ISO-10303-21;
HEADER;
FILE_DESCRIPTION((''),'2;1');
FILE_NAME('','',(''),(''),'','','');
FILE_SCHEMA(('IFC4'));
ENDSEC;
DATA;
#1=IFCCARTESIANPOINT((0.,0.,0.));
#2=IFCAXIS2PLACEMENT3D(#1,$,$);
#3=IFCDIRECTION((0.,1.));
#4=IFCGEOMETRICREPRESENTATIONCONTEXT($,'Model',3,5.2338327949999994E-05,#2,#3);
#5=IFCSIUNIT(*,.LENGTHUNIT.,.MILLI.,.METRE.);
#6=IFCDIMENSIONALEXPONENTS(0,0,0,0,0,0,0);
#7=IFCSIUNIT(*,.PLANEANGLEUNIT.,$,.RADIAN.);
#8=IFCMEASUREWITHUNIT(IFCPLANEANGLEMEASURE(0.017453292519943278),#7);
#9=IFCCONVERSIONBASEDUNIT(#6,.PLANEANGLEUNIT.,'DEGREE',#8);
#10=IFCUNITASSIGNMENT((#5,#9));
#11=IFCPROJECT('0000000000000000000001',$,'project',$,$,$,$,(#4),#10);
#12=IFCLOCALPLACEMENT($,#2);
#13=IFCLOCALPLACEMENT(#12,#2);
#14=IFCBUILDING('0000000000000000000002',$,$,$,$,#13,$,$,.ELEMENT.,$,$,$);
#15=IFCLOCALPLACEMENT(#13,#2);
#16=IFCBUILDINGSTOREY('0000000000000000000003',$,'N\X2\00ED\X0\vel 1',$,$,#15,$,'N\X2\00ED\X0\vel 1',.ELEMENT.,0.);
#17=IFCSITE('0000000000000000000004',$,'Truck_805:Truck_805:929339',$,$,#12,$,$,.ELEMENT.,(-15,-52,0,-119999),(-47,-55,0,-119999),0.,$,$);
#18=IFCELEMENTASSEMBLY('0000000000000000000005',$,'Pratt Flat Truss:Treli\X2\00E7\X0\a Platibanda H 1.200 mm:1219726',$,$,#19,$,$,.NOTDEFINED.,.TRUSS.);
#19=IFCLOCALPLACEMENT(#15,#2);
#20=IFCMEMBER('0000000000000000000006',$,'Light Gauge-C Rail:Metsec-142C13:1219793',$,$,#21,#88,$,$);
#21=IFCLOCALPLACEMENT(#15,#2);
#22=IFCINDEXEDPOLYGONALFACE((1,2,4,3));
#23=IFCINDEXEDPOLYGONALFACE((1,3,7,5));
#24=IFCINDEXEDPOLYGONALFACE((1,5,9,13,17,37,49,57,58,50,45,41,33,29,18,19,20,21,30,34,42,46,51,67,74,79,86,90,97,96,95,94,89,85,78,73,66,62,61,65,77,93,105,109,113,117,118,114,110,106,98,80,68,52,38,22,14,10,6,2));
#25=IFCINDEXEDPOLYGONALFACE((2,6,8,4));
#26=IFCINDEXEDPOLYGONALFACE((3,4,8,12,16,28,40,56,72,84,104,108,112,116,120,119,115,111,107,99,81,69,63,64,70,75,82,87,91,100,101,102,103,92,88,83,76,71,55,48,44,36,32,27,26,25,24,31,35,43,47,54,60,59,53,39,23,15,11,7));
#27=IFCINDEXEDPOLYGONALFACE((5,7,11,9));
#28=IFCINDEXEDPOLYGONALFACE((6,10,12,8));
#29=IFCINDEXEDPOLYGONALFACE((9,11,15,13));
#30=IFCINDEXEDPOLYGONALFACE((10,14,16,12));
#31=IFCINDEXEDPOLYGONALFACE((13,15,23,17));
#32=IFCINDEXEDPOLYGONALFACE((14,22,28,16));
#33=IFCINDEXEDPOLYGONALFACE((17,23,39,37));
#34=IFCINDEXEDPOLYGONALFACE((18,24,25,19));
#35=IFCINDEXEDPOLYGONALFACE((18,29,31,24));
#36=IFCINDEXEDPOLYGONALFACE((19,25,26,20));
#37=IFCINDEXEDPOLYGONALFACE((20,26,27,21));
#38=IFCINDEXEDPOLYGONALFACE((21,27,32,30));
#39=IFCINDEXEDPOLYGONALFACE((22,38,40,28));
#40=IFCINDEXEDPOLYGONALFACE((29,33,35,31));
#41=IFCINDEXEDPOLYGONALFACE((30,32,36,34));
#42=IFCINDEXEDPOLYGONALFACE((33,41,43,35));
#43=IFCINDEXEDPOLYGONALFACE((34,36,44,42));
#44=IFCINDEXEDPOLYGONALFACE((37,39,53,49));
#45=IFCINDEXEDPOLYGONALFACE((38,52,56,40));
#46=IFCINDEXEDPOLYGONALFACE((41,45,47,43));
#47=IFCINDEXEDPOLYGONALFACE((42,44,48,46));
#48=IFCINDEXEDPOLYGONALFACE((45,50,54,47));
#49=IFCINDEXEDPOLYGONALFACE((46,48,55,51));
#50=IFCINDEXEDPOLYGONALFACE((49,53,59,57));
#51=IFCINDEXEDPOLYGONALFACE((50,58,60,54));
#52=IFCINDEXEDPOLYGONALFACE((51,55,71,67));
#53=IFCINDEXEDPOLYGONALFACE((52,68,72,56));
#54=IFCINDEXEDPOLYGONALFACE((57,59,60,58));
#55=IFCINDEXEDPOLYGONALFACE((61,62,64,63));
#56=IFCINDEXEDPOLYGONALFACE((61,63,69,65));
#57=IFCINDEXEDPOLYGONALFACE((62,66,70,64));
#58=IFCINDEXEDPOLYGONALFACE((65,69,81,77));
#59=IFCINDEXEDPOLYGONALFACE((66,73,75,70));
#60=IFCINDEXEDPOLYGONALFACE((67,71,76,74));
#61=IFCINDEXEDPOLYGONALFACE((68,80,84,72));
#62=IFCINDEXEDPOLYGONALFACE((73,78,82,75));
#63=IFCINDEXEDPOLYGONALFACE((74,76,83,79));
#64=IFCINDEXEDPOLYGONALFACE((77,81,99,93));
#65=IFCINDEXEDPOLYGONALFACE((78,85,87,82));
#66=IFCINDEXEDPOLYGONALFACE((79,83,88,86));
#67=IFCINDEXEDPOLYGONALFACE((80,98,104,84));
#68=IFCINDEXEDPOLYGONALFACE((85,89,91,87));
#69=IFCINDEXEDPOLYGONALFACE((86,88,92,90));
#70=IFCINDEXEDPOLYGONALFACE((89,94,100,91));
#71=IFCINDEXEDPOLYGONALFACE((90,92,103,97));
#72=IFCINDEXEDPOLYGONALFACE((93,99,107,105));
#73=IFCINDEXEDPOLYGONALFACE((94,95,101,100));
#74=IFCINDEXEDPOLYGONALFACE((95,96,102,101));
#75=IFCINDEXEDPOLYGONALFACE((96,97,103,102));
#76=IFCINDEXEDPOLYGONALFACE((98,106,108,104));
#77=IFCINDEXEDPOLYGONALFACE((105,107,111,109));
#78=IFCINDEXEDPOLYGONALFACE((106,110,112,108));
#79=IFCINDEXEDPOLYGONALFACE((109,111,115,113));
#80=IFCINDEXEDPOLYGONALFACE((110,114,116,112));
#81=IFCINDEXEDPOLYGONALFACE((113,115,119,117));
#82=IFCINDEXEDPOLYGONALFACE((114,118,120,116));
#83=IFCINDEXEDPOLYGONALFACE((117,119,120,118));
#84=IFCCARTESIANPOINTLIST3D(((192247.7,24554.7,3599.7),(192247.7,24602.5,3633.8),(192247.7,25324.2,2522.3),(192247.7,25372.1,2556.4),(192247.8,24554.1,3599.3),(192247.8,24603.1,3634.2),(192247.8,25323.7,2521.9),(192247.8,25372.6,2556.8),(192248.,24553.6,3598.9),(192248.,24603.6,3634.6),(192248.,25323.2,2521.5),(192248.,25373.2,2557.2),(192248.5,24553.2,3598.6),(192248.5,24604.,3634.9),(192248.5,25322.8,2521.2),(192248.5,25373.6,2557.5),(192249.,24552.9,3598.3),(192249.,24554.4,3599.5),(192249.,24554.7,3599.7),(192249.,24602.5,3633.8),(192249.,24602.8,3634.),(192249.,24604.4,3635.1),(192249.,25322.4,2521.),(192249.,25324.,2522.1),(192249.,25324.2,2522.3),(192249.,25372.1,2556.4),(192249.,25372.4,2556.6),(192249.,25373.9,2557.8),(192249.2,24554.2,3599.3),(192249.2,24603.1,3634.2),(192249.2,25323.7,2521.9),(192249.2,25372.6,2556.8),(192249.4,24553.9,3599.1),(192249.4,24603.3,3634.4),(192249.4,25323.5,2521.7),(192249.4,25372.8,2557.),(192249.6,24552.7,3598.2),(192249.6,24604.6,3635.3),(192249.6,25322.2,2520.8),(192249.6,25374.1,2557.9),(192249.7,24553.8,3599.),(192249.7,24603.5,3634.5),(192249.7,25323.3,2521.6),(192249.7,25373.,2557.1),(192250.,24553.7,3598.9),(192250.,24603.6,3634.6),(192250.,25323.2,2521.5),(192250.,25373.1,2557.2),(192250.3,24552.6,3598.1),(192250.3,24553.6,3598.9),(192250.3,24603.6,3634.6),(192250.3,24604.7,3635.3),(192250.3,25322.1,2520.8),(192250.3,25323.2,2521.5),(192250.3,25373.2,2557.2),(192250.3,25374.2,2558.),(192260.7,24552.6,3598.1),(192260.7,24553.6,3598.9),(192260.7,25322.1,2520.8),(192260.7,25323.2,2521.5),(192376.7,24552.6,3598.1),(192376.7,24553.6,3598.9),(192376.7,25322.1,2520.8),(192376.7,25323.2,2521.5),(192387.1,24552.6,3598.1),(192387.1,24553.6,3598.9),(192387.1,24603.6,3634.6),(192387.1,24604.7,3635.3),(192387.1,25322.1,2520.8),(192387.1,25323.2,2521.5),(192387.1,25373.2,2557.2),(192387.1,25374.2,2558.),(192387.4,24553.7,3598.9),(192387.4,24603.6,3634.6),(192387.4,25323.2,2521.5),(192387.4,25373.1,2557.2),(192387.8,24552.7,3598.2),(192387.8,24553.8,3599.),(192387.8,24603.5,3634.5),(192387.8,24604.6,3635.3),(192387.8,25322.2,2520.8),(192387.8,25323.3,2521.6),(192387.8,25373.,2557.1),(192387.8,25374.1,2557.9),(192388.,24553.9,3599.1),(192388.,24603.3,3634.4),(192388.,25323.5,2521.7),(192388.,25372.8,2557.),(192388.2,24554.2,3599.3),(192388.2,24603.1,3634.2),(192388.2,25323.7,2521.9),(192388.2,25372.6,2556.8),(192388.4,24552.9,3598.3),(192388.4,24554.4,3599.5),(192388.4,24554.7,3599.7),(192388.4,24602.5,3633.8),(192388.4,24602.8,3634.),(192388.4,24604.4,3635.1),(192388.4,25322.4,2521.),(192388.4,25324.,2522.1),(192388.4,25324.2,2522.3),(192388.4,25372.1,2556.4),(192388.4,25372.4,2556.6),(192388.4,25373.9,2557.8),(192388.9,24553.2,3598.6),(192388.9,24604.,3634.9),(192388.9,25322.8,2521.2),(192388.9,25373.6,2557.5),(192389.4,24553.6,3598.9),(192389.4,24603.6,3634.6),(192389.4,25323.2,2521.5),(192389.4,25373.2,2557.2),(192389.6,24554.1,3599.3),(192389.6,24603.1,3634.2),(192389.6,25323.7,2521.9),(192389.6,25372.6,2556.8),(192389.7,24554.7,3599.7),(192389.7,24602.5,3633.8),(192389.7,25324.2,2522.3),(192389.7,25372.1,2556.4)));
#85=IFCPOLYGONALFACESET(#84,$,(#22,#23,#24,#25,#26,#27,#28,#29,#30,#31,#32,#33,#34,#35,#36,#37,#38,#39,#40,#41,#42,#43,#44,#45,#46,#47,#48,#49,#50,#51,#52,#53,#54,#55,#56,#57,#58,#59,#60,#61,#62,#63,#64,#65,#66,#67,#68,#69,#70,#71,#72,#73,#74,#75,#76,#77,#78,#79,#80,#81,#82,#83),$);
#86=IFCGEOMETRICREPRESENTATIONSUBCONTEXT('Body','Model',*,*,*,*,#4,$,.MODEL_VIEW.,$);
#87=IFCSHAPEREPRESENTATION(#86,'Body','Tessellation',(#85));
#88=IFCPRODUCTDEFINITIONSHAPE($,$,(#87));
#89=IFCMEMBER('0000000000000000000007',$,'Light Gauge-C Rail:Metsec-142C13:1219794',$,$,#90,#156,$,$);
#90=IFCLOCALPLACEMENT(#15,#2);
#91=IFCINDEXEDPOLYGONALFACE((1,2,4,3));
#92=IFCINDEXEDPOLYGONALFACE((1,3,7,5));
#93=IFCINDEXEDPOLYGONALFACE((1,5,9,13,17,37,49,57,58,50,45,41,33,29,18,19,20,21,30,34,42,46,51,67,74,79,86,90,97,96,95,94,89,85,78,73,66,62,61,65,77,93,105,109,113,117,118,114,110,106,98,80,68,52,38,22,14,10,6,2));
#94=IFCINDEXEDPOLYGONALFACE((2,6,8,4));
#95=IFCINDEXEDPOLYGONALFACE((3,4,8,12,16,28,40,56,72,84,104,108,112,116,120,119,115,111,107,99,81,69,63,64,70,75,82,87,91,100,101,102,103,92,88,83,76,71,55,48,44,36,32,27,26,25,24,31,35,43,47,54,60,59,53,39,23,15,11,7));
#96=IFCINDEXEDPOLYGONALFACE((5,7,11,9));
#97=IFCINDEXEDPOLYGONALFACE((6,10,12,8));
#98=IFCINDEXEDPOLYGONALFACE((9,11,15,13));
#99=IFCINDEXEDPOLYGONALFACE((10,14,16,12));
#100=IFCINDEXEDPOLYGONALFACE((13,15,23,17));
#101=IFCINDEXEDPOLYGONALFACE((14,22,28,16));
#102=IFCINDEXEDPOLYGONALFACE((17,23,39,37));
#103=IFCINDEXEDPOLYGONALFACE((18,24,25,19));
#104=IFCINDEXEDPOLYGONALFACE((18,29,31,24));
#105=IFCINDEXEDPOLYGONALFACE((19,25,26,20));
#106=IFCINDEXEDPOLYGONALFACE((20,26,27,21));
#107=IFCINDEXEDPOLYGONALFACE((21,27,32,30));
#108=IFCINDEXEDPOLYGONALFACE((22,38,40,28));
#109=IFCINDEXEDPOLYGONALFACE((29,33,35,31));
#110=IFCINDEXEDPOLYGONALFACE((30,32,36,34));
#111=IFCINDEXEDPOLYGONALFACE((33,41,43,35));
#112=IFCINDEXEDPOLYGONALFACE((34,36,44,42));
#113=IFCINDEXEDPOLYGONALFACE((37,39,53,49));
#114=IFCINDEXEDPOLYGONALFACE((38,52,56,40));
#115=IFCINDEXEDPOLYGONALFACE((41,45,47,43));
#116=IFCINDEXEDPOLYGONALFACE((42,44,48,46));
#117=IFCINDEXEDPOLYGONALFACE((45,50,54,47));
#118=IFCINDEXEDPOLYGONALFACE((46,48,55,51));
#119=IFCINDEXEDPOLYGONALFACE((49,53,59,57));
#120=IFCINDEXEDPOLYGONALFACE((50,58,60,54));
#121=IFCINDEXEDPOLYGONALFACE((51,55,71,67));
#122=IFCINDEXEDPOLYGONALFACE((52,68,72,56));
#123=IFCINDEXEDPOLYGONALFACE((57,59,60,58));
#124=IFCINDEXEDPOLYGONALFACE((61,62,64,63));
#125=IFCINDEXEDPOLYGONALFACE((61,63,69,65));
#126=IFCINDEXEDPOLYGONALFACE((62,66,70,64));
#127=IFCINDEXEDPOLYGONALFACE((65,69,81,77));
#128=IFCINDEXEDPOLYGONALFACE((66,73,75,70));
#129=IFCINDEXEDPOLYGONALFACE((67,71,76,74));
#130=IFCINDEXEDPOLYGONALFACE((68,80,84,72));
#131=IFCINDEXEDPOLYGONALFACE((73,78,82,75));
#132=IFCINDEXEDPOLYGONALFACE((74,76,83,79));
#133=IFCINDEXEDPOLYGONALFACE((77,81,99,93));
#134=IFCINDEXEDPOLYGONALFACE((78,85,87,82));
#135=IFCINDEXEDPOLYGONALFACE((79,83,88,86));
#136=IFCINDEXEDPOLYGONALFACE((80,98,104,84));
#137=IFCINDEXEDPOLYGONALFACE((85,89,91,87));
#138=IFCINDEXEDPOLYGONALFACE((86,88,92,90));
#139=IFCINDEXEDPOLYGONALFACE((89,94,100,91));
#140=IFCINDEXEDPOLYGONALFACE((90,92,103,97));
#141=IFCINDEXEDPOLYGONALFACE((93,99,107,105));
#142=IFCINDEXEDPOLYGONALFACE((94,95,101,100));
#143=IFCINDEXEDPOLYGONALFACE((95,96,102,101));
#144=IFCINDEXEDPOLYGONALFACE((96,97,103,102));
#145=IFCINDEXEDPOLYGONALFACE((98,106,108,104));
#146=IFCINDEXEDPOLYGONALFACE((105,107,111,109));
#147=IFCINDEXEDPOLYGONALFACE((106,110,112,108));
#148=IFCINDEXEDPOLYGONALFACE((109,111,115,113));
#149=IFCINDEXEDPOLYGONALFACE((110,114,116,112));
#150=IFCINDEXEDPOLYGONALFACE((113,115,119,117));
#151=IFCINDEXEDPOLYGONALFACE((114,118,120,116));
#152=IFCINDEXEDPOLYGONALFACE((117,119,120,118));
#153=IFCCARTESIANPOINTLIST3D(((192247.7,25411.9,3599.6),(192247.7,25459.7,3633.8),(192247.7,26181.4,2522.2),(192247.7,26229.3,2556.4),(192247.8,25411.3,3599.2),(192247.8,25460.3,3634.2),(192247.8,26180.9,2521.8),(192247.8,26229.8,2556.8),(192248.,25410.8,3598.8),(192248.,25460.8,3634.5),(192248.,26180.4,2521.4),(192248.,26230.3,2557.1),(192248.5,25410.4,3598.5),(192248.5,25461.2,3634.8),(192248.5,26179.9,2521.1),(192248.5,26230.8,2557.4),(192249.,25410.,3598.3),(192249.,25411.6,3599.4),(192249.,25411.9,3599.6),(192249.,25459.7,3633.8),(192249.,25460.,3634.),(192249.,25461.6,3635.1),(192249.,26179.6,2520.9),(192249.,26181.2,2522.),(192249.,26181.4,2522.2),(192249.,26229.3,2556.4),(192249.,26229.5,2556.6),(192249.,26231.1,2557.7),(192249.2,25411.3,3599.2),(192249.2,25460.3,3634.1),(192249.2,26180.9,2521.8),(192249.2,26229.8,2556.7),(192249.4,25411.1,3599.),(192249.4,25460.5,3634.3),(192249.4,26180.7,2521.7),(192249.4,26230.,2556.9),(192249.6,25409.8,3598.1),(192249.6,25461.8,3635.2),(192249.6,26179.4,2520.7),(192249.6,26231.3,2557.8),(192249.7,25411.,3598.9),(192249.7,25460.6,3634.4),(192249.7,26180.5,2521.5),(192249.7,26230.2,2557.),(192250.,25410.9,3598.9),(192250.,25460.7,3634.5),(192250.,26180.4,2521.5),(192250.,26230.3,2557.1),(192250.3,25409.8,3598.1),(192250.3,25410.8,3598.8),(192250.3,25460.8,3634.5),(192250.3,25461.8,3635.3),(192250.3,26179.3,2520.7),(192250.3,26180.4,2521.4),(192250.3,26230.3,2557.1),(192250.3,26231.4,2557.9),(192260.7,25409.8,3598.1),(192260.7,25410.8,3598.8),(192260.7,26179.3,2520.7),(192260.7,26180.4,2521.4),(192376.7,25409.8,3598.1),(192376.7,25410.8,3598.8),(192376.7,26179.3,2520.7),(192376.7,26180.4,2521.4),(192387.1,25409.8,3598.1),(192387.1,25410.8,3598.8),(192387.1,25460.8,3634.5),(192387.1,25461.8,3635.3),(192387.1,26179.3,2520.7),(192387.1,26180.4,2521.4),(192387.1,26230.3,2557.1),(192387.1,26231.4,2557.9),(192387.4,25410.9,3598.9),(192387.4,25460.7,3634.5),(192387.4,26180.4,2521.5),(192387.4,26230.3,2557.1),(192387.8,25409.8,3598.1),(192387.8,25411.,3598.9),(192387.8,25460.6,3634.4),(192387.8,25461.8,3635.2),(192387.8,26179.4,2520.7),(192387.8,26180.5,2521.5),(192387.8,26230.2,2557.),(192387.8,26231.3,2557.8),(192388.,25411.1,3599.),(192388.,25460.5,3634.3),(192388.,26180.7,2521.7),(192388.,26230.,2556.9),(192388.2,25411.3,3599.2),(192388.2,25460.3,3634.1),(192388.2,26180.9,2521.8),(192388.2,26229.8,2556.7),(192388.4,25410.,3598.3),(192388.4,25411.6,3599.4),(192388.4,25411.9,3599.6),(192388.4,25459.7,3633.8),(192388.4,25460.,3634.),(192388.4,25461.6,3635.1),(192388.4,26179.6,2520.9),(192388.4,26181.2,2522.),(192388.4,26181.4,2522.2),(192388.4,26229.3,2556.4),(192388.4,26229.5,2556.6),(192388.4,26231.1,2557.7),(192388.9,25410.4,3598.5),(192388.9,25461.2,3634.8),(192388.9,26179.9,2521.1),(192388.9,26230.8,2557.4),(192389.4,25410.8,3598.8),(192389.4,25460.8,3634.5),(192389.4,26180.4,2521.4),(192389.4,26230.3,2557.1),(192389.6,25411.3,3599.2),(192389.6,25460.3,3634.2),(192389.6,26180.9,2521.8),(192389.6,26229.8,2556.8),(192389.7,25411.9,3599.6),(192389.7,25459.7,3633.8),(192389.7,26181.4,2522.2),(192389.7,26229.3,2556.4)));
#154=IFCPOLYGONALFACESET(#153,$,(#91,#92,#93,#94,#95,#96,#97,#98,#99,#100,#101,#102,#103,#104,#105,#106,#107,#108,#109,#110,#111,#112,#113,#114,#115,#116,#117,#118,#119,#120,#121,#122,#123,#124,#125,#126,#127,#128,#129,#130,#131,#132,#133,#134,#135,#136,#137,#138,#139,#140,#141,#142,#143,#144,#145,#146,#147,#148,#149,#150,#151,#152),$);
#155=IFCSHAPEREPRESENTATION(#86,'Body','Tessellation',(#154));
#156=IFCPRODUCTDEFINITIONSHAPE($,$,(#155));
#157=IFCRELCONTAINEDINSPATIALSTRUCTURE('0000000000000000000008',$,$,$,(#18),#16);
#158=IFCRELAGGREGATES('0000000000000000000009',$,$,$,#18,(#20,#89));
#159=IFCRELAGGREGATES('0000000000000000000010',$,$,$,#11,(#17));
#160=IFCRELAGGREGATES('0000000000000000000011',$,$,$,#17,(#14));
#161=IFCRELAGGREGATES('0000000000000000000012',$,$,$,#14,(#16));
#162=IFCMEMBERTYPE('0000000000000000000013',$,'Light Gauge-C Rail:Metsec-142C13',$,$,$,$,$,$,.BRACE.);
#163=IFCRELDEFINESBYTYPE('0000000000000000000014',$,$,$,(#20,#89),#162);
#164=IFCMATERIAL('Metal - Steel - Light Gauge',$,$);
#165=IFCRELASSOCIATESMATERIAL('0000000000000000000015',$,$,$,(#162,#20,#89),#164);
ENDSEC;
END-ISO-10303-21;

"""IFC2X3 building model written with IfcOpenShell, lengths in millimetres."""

from ifc_helpers import new_model, entity, si_unit, converted_unit, direction, frame, frame_2d, origin, place, context, subcontext, project, spatial, polyline, circle_curve, parameter, trimmed, segment, composite_curve, outline, extrude, source, transform, mapped, material, type_object, type_shapes, element, aggregate, save


model = new_model("IFC2X3")

# Units and contexts
model_context = context("Model", 3, precision=5.2338327949999994e-05, world=origin(), true_north=direction((0.0, 1.0)))
body_context = subcontext(model_context, "Body", "Model", "MODEL_VIEW")
ifc_project = project(units=[si_unit("LENGTHUNIT", "METRE", prefix="MILLI"), converted_unit("PLANEANGLEUNIT", "DEGREE", entity("IfcPlaneAngleMeasure", 0.017453292519943278), si_unit("PLANEANGLEUNIT", "RADIAN"), dimensions=[0, 0, 0, 0, 0, 0, 0])], contexts=[model_context])

# Site, building, storey
site_placement = place(None, origin())
site = spatial("IfcSite", under=ifc_project, at=site_placement, Name="Truck_805:Truck_805:929339", CompositionType="ELEMENT", RefLatitude=(-15, -52, 0, -119999), RefLongitude=(-47, -55, 0, -119999), RefElevation=0.0)
building_placement = place(site_placement, origin())
building = spatial("IfcBuilding", under=site, at=building_placement, CompositionType="ELEMENT")
storey_placement = place(building_placement, origin())
storey = spatial("IfcBuildingStorey", under=building, at=storey_placement, Name="Nível 1", LongName="Nível 1", CompositionType="ELEMENT", Elevation=0.0)

# Element assembly, members
assembly_1_placement = place(storey_placement, origin())
assembly_1 = element("IfcElementAssembly", 1, at=assembly_1_placement, inside=storey, Name="Pratt Flat Truss:Treliça Platibanda H 1.200 mm:1219726", AssemblyPlace="NOTDEFINED", PredefinedType="TRUSS")
ifc_material_1 = material(Name="Metal - Steel - Light Gauge")
member_type_1 = type_object("IfcMemberType", Name="Light Gauge-C Rail:Metsec-142C13", PredefinedType="BRACE", material=ifc_material_1)
shared_shape_1 = source(origin(), body_context, "Body", "SweptSolid", [
    extrude(outline(composite_curve([segment(polyline([(-23.1, -71.0), (35.7, -71.0)]), True, "CONTINUOUS"), segment(trimmed(circle_curve(frame_2d((35.7, -68.4), x_axis=(0.0, -1.0)), 2.6), [parameter(0.0)], [parameter(90.0)], True, "PARAMETER"), True, "CONTINUOUS"), segment(polyline([(38.3, -68.4), (38.3, 68.4)]), True, "CONTINUOUS"), segment(trimmed(circle_curve(frame_2d((35.7, 68.4), x_axis=(1.0, 0.0)), 2.6), [parameter(0.0)], [parameter(90.0)], True, "PARAMETER"), True, "CONTINUOUS"), segment(polyline([(35.7, 71.0), (-23.1, 71.0)]), True, "CONTINUOUS"), segment(trimmed(circle_curve(frame_2d((-23.1, 68.4), x_axis=(0.0, 1.0)), 2.6), [parameter(0.0)], [parameter(90.0)], True, "PARAMETER"), True, "CONTINUOUS"), segment(polyline([(-25.7, 68.4), (-25.7, 58.0)]), True, "CONTINUOUS"), segment(polyline([(-25.7, 58.0), (-24.4, 58.0)]), True, "CONTINUOUS"), segment(polyline([(-24.4, 58.0), (-24.4, 68.4)]), True, "CONTINUOUS"), segment(trimmed(circle_curve(frame_2d((-23.1, 68.4), x_axis=(-1.0, 0.0)), 1.3), [parameter(270.0)], [parameter(0.0)], True, "PARAMETER"), False, "CONTINUOUS"), segment(polyline([(-23.1, 69.7), (35.7, 69.7)]), True, "CONTINUOUS"), segment(trimmed(circle_curve(frame_2d((35.7, 68.4), x_axis=(0.0, 1.0)), 1.3), [parameter(270.0)], [parameter(0.0)], True, "PARAMETER"), False, "CONTINUOUS"), segment(polyline([(37.0, 68.4), (37.0, -68.4)]), True, "CONTINUOUS"), segment(trimmed(circle_curve(frame_2d((35.7, -68.4), x_axis=(1.0, 0.0)), 1.3), [parameter(270.0)], [parameter(0.0)], True, "PARAMETER"), False, "CONTINUOUS"), segment(polyline([(35.7, -69.7), (-23.1, -69.7)]), True, "CONTINUOUS"), segment(trimmed(circle_curve(frame_2d((-23.1, -68.4), x_axis=(0.0, -1.0)), 1.3), [parameter(270.0)], [parameter(0.0)], True, "PARAMETER"), False, "CONTINUOUS"), segment(polyline([(-24.4, -68.4), (-24.4, -58.0)]), True, "CONTINUOUS"), segment(polyline([(-24.4, -58.0), (-25.7, -58.0)]), True, "CONTINUOUS"), segment(polyline([(-25.7, -58.0), (-25.7, -68.4)]), True, "CONTINUOUS"), segment(trimmed(circle_curve(frame_2d((-23.1, -68.4), x_axis=(-1.0, 0.0)), 2.6), [parameter(0.0)], [parameter(90.0)], True, "PARAMETER"), True, "CONTINUOUS")], self_intersect=False)), frame((-653.0, 0.0, 18.8), z_axis=(1.0, 0.0, 0.0), x_axis=(0.0, 0.0, -1.0)), (0.0, 0.0, 1.0), 1324.0),
])
type_shapes(member_type_1, [shared_shape_1])
member_1_placement = place(assembly_1_placement, frame((192318.7, 24978.8, 3078.0), z_axis=(0.0, -0.813738, -0.581231), x_axis=(0.0, -0.581231, 0.813738)))
member_1 = element("IfcMember", 2, at=member_1_placement, type_object=member_type_1, material=ifc_material_1, Name="Light Gauge-C Rail:Metsec-142C13:1219793", context=body_context, shape_type="MappedRepresentation", body=[
    mapped(shared_shape_1, transform((0.0, 0.0, 0.0), scale=1.0)),
])
member_2_placement = place(assembly_1_placement, frame((192318.7, 25836.0, 3077.9), z_axis=(0.0, -0.813738, -0.581231), x_axis=(0.0, -0.581231, 0.813738)))
member_2 = element("IfcMember", 3, at=member_2_placement, type_object=member_type_1, material=ifc_material_1, Name="Light Gauge-C Rail:Metsec-142C13:1219794", context=body_context, shape_type="MappedRepresentation", body=[
    mapped(shared_shape_1, transform((0.0, 0.0, 0.0), scale=1.0)),
])
aggregate(assembly_1, [member_1, member_2])

save(model, "model.ifc")
